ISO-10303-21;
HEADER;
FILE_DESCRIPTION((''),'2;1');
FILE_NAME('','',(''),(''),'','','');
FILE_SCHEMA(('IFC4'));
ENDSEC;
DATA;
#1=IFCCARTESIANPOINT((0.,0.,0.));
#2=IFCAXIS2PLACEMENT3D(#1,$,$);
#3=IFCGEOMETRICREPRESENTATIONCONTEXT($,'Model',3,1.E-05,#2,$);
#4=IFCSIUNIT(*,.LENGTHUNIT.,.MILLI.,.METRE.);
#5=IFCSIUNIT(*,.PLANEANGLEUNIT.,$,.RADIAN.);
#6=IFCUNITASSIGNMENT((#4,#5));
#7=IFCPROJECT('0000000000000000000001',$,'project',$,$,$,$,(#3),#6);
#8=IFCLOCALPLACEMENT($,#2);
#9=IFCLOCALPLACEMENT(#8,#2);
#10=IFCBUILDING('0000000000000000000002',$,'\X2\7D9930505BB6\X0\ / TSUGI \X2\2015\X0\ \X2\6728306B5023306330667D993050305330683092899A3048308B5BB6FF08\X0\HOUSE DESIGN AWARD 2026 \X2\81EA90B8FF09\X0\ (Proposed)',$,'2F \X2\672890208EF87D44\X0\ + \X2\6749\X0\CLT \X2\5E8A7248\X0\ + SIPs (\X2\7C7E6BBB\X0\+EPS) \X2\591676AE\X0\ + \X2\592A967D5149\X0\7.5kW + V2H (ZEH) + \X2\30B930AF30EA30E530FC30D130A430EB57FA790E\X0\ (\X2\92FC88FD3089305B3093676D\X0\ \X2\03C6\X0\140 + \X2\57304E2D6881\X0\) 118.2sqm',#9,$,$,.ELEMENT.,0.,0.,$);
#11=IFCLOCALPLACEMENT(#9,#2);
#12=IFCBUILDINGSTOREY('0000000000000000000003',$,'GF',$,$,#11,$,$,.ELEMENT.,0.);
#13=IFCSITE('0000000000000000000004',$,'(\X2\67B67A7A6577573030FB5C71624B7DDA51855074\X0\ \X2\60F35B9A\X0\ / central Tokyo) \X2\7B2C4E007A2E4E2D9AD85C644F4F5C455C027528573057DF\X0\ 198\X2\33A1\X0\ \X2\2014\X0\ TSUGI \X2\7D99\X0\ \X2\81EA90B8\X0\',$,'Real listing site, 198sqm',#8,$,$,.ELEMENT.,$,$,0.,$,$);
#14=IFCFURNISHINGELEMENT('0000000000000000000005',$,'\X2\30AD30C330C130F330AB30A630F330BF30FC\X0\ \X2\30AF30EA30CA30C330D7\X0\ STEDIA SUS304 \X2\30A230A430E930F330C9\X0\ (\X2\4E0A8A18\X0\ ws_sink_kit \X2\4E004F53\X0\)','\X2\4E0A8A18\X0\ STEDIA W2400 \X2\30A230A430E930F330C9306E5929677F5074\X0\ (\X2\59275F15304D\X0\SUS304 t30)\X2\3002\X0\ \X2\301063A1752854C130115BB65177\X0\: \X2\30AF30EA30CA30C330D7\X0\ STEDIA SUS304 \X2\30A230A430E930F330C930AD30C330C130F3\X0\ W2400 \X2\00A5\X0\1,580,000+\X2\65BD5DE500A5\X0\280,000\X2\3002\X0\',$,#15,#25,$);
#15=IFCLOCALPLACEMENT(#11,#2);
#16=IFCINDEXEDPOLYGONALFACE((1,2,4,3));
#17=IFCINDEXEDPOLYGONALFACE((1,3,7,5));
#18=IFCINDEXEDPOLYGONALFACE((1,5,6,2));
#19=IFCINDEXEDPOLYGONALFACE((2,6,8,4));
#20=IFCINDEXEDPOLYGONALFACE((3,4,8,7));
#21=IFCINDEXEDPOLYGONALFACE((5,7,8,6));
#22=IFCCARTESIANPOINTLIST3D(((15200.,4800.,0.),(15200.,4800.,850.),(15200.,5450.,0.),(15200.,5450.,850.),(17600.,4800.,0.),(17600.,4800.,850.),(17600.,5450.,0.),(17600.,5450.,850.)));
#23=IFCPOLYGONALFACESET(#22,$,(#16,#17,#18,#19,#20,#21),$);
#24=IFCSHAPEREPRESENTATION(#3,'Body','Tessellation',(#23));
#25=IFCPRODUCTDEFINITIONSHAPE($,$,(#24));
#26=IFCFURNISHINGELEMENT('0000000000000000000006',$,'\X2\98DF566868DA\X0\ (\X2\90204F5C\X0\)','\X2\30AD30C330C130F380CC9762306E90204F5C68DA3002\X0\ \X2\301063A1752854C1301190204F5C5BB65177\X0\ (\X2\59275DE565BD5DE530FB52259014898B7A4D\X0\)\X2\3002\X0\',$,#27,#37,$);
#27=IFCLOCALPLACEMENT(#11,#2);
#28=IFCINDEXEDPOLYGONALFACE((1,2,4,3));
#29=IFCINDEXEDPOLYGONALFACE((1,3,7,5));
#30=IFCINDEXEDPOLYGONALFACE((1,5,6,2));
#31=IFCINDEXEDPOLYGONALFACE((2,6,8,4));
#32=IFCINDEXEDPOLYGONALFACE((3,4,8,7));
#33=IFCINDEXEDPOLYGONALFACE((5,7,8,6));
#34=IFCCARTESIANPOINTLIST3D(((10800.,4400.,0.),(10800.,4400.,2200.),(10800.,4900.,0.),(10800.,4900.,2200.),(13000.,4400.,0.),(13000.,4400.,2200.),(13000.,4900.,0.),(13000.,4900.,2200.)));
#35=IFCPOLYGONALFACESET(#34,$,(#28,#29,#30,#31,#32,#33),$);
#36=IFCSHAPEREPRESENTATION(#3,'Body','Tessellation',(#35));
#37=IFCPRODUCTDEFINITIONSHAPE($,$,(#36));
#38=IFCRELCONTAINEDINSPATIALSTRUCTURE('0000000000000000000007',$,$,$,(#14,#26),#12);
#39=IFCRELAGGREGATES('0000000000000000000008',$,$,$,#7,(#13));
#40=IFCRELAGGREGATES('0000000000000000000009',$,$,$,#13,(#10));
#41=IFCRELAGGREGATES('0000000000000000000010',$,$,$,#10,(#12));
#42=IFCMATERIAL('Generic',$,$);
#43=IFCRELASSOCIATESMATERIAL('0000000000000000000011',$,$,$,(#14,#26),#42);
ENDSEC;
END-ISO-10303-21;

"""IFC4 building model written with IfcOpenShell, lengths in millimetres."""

from ifc_helpers import new_model, si_unit, frame, frame_2d, origin, place, context, project, spatial, rectangle, extrude, material, element, save


model = new_model("IFC4")

# Units and contexts
model_context = context("Model", 3, precision=1e-05, world=origin())
ifc_project = project(units=[si_unit("LENGTHUNIT", "METRE", prefix="MILLI"), si_unit("PLANEANGLEUNIT", "RADIAN")], contexts=[model_context])

# Site, building, storey
site_placement = place(None, origin())
site = spatial("IfcSite", under=ifc_project, at=site_placement, Name="(架空敷地・山手線内側 想定 / central Tokyo) 第一種中高層住居専用地域 198㎡ — TSUGI 継 自邸", ObjectType="Real listing site, 198sqm", CompositionType="ELEMENT", RefElevation=0.0)
building_placement = place(site_placement, origin())
building = spatial("IfcBuilding", under=site, at=building_placement, Name="継ぐ家 / TSUGI ― 木に倣って継ぐことを覚える家（HOUSE DESIGN AWARD 2026 自邸） (Proposed)", ObjectType="2F 木造軸組 + 杉CLT 床版 + SIPs (籾殻+EPS) 外皮 + 太陽光7.5kW + V2H (ZEH) + スクリューパイル基礎 (鋼製らせん杭 φ140 + 地中梁) 118.2sqm", CompositionType="ELEMENT", ElevationOfRefHeight=0.0, ElevationOfTerrain=0.0)
storey_placement = place(building_placement, origin())
storey = spatial("IfcBuildingStorey", under=building, at=storey_placement, Name="GF", CompositionType="ELEMENT", Elevation=0.0)

# Shared definitions
ifc_material_1 = material(Name="Generic")

# Furnishing elements
furnishing_1_placement = place(storey_placement, frame((7600.0, 2400.0, 0.0)))
element("IfcFurnishingElement", 1, at=furnishing_1_placement, inside=storey, material=ifc_material_1, Name="キッチンカウンター クリナップ STEDIA SUS304 アイランド (上記 ws_sink_kit 一体)", Description="上記 STEDIA W2400 アイランドの天板側 (大引きSUS304 t30)。 【採用品】家具: クリナップ STEDIA SUS304 アイランドキッチン W2400 ¥1,580,000+施工¥280,000。", context=model_context, shape_type="SweptSolid", body=[
    extrude(rectangle(XDim=2400.0, YDim=650.0, at=frame_2d((1200.0, 325.0))), frame((7600.0, 2400.0, 0.0)), (0.0, 0.0, 1.0), 850.0),
])
furnishing_2_placement = place(storey_placement, frame((5400.0, 2200.0, 0.0)))
element("IfcFurnishingElement", 2, at=furnishing_2_placement, inside=storey, material=ifc_material_1, Name="食器棚 (造作)", Description="キッチン背面の造作棚。 【採用品】造作家具 (大工施工・別途見積)。", context=model_context, shape_type="SweptSolid", body=[
    extrude(rectangle(XDim=2200.0, YDim=500.0, at=frame_2d((1100.0, 250.0))), frame((5400.0, 2200.0, 0.0)), (0.0, 0.0, 1.0), 2200.0),
])

save(model, "model.ifc")
